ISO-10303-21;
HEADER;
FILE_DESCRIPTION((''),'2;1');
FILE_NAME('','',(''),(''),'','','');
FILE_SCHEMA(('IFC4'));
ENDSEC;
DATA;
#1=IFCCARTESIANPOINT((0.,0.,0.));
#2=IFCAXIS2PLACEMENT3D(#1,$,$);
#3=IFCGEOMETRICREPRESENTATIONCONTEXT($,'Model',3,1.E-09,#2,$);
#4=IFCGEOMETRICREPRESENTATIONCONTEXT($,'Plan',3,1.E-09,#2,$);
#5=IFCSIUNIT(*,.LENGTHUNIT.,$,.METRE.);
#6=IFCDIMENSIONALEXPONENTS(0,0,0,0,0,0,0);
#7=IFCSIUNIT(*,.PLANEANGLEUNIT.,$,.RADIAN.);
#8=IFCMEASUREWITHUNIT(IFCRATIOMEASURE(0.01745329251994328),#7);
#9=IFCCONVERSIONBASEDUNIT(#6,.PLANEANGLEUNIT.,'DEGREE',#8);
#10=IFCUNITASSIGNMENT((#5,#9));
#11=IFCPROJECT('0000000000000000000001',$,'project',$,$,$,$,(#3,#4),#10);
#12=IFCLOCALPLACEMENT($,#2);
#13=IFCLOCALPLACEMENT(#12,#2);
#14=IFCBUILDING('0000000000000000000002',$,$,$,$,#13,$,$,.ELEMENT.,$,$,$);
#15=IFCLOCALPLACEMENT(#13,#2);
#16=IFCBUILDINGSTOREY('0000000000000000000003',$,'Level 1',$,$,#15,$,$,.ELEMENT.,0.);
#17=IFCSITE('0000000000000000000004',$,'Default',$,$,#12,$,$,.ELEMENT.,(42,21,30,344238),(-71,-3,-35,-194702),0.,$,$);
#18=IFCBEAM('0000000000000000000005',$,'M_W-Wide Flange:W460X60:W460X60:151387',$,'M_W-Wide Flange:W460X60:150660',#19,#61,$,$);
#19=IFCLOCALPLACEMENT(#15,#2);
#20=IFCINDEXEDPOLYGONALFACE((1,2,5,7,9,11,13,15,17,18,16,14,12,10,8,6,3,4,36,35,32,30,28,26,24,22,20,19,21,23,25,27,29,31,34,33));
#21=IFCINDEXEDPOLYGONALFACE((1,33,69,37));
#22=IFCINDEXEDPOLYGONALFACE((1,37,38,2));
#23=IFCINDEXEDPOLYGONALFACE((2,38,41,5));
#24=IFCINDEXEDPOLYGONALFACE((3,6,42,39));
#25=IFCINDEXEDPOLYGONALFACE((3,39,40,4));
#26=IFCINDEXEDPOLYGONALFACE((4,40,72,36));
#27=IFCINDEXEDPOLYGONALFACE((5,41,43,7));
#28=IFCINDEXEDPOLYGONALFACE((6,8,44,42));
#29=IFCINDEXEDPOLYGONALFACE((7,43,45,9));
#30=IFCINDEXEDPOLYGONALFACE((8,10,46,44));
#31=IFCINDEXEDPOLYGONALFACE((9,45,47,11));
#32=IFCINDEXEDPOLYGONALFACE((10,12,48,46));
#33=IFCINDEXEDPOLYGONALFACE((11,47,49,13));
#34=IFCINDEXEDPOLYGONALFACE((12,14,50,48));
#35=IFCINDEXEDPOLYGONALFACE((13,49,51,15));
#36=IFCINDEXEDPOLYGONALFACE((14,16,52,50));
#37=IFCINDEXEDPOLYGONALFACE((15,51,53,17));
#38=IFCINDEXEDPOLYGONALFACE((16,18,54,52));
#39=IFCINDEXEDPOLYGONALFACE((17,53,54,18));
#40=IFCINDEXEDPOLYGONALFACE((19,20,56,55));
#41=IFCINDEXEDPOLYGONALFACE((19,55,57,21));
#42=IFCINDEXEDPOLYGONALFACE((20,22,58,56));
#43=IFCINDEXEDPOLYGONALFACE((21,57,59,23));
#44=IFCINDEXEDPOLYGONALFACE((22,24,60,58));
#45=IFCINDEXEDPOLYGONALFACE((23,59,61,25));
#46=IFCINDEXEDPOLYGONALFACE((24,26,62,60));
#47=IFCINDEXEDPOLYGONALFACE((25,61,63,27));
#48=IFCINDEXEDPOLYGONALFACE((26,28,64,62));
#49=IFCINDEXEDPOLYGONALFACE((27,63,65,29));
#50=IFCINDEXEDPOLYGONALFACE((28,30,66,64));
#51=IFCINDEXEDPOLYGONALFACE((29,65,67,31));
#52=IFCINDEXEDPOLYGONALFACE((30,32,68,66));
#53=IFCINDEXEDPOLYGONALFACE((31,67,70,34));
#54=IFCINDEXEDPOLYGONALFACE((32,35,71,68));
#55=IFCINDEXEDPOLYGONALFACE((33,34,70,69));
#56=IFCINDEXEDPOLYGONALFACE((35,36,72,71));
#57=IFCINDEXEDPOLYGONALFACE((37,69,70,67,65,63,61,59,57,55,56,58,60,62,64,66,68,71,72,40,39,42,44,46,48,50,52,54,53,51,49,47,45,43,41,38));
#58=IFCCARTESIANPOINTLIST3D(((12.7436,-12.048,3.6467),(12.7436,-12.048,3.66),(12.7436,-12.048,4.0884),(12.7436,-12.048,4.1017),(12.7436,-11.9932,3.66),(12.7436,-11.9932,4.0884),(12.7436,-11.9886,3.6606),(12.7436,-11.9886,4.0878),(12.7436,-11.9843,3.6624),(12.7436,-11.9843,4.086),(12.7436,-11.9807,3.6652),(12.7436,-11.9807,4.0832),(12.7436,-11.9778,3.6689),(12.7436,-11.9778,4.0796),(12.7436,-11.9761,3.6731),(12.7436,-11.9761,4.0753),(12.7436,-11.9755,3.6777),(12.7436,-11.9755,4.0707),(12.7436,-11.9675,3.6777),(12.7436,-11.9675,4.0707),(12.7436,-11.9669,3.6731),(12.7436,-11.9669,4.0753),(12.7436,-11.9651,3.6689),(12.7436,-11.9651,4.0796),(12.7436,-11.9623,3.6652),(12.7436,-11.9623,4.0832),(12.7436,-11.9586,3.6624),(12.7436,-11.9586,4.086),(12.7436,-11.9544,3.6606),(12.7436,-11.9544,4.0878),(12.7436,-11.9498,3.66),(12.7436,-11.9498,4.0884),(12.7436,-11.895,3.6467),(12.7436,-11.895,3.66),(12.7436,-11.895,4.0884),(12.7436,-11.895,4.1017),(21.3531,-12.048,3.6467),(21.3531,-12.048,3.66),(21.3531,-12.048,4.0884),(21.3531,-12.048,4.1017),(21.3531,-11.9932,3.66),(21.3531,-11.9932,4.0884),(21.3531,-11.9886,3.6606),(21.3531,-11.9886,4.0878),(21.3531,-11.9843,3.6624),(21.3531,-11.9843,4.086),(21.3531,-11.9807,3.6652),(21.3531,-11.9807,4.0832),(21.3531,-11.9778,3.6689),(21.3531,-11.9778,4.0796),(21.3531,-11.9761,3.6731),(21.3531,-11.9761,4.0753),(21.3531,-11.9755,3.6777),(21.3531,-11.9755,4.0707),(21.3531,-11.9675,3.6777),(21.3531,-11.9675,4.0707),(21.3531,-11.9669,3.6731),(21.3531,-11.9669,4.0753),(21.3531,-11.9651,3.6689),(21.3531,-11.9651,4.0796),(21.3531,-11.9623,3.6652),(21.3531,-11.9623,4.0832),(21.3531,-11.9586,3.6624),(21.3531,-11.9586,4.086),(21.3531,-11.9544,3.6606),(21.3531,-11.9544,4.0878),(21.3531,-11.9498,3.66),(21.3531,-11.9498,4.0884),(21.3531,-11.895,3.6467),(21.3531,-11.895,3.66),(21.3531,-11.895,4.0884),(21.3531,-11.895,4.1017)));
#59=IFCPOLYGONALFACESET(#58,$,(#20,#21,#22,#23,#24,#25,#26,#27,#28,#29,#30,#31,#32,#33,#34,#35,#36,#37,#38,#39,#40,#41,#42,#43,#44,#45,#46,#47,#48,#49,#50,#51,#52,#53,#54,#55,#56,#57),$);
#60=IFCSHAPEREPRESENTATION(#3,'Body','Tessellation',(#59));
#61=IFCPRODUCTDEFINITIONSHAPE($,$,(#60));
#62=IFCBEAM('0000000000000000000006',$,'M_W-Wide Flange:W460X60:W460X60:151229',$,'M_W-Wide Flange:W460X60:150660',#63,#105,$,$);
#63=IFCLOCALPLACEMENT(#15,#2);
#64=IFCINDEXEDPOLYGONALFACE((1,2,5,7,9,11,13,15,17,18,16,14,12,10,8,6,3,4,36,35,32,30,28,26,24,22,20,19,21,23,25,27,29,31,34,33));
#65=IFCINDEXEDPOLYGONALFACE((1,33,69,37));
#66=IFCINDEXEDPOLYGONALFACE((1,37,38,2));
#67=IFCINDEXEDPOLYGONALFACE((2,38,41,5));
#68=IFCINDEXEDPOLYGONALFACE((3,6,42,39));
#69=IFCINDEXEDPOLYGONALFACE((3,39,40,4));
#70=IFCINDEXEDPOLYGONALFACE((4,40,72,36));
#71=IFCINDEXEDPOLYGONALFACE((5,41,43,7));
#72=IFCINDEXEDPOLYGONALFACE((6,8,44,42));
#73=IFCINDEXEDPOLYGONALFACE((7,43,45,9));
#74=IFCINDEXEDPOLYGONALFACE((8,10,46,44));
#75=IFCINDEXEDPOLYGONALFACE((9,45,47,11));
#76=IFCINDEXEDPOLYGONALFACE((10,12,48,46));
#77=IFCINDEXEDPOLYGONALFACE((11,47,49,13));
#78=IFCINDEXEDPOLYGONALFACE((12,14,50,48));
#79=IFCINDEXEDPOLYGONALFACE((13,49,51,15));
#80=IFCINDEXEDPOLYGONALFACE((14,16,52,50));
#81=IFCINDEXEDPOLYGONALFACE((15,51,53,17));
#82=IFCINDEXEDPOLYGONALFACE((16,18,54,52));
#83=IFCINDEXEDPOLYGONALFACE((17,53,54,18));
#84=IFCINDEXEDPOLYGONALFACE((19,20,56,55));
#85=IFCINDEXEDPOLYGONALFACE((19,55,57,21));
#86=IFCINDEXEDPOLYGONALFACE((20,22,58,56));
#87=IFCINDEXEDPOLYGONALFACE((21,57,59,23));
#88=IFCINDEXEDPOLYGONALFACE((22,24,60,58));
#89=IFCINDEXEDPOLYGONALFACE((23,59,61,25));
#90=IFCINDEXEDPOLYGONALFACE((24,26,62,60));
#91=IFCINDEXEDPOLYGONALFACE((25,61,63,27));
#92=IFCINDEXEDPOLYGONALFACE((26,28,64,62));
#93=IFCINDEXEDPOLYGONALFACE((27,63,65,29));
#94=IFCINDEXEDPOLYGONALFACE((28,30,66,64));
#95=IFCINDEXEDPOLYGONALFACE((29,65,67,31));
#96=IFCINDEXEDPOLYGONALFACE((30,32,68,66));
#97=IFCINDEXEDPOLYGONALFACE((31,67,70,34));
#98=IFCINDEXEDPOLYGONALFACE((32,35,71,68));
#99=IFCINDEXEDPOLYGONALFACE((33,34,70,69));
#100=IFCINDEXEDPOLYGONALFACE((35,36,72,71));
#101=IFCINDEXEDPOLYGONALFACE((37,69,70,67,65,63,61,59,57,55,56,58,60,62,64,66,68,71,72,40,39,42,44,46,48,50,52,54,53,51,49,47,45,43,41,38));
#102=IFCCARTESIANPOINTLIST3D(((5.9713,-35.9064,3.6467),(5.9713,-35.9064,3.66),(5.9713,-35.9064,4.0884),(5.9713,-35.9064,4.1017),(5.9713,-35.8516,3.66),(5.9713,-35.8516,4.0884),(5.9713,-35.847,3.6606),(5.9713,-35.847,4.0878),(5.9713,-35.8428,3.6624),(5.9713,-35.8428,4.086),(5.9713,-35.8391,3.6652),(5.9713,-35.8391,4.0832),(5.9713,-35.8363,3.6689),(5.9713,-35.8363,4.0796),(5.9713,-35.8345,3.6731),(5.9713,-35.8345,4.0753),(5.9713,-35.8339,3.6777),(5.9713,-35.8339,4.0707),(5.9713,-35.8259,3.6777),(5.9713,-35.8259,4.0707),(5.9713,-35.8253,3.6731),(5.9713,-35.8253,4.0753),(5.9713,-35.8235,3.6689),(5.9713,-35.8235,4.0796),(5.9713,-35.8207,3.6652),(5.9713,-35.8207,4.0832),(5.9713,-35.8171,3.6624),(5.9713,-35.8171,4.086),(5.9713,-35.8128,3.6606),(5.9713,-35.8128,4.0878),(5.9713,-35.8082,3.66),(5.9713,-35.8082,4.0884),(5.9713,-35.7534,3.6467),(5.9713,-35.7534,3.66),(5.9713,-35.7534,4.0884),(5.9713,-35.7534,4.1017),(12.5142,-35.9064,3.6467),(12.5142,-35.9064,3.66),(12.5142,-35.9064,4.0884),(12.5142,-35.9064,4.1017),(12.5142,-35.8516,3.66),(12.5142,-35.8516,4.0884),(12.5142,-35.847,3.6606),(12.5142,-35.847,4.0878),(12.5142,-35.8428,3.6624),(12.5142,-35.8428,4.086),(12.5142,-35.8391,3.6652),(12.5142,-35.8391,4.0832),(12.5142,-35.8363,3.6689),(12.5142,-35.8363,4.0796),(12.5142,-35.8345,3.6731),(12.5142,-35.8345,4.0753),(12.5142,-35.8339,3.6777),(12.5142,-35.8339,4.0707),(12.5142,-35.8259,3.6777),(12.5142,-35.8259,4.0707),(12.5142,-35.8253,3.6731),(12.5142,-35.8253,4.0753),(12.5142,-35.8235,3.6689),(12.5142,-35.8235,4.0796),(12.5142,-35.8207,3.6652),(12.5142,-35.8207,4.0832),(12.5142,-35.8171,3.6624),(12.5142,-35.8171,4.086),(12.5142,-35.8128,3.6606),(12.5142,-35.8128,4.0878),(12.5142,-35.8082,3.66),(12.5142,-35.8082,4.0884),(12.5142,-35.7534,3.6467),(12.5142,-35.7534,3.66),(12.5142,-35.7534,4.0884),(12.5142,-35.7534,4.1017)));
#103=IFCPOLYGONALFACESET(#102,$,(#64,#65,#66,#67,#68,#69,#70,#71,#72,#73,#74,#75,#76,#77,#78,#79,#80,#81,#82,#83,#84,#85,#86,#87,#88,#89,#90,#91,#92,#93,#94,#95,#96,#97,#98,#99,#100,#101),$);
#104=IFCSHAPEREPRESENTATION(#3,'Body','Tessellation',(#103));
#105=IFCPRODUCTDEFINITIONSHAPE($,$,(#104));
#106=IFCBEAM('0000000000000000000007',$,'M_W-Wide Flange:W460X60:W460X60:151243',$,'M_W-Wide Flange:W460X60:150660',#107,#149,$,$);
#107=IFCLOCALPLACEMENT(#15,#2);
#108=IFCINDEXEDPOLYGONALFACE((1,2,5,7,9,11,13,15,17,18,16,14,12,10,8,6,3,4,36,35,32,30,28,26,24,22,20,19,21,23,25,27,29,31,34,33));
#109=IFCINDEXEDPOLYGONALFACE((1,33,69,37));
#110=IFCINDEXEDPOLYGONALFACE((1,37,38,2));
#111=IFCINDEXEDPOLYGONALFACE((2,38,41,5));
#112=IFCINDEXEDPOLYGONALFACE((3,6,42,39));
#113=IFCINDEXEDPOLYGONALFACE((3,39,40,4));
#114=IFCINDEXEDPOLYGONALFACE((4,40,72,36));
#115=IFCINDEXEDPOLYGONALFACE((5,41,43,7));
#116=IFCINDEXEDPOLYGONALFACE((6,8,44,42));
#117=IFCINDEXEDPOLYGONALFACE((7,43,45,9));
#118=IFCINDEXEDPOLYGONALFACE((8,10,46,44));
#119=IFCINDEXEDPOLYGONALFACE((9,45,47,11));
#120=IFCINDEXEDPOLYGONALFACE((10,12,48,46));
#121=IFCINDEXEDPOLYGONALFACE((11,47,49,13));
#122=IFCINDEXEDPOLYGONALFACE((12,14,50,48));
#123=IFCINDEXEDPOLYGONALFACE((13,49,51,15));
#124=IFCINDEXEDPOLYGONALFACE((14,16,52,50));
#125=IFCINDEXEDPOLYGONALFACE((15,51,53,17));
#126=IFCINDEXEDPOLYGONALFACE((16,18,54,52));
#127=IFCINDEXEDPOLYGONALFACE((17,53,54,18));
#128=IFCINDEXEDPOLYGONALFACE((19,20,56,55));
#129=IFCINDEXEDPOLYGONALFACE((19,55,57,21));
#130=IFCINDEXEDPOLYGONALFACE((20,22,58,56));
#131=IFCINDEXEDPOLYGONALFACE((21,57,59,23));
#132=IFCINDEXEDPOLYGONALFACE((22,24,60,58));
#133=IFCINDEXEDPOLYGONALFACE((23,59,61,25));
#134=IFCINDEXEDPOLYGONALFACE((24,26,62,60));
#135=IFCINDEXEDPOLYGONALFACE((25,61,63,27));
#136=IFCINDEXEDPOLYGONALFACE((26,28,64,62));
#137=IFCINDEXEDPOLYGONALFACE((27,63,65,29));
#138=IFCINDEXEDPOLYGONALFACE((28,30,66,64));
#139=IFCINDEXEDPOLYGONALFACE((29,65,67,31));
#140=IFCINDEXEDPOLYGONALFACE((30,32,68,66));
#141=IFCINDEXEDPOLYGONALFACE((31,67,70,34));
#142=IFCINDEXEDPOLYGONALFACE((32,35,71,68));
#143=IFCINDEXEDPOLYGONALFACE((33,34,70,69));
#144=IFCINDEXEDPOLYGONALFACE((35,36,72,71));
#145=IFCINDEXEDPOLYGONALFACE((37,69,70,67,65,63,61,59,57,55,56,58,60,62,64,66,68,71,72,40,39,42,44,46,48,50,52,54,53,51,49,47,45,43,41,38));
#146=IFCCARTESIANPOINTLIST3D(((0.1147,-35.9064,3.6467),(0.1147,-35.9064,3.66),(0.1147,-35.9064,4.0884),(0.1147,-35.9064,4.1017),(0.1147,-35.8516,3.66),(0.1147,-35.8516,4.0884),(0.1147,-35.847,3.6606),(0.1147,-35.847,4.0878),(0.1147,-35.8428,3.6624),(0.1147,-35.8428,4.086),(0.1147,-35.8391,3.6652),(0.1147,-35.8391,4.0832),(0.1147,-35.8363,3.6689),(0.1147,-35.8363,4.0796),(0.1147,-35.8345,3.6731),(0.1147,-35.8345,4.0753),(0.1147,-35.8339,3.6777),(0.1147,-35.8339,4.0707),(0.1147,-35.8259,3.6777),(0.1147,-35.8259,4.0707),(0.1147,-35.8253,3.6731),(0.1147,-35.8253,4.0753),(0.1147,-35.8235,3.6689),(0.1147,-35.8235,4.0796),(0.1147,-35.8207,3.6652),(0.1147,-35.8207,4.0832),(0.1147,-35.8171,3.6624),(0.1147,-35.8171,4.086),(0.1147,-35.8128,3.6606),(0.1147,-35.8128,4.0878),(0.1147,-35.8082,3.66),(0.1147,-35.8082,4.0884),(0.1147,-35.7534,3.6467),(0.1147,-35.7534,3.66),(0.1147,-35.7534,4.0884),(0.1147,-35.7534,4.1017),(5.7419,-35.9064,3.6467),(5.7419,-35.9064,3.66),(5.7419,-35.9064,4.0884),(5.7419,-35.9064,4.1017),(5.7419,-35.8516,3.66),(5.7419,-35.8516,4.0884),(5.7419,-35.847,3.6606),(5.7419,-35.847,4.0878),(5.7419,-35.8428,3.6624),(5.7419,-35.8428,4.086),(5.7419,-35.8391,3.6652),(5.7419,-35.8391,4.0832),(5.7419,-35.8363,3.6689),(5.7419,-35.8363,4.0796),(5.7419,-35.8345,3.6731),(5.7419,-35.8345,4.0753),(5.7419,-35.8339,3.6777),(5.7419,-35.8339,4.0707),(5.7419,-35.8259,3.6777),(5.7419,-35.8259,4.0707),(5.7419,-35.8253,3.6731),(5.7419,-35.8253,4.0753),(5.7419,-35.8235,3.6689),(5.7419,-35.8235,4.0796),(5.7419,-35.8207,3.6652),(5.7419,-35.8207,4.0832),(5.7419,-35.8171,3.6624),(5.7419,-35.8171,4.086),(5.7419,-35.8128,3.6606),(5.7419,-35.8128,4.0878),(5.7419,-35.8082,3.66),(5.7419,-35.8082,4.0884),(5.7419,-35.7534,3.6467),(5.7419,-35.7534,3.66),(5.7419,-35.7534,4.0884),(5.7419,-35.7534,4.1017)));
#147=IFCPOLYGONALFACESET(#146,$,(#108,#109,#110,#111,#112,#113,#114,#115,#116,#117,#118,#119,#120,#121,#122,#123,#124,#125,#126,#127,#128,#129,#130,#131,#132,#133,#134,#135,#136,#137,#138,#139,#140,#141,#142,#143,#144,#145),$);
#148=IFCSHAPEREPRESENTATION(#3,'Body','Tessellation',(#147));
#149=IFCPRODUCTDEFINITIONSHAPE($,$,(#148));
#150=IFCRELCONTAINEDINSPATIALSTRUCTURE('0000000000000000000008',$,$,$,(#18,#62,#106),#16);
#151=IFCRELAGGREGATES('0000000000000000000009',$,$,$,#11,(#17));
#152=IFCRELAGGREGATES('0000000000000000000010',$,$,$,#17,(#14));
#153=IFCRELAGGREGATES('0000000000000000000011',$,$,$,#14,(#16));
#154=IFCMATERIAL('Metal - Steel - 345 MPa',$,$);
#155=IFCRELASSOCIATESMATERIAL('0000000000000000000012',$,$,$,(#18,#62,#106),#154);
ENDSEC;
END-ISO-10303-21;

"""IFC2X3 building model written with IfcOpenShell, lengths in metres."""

from ifc_helpers import new_model, entity, si_unit, converted_unit, frame, frame_2d, origin, place, context, project, spatial, polyline, circle_curve, parameter, trimmed, segment, composite_curve, outline, extrude, material, element, save


model = new_model("IFC2X3")

# Units and contexts
model_context = context("Model", 3, precision=1e-09, world=origin())
plan_context = context("Plan", 3, precision=1e-09, world=origin())
ifc_project = project(units=[si_unit("LENGTHUNIT", "METRE"), converted_unit("PLANEANGLEUNIT", "DEGREE", entity("IfcRatioMeasure", 0.01745329251994328), si_unit("PLANEANGLEUNIT", "RADIAN"), dimensions=[0, 0, 0, 0, 0, 0, 0])], contexts=[model_context, plan_context])

# Site, building, storey
site_placement = place(None, origin())
site = spatial("IfcSite", under=ifc_project, at=site_placement, Name="Default", CompositionType="ELEMENT", RefLatitude=(42, 21, 30, 344238), RefLongitude=(-71, -3, -35, -194702), RefElevation=0.0)
building_placement = place(site_placement, origin())
building = spatial("IfcBuilding", under=site, at=building_placement, CompositionType="ELEMENT")
storey_placement = place(building_placement, origin())
storey = spatial("IfcBuildingStorey", under=building, at=storey_placement, Name="Level 1", CompositionType="ELEMENT", Elevation=0.0)

# Beams
ifc_material_1 = material(Name="Metal - Steel - 345 MPa")
beam_1_placement = place(storey_placement, frame((12.6289, -11.9715, 4.2672), z_axis=(0.0, 0.0, 1.0), x_axis=(0.0, -1.0, 0.0)))
element("IfcBeam", 1, at=beam_1_placement, inside=storey, material=ifc_material_1, Name="M_W-Wide Flange:W460X60:W460X60:151387", ObjectType="M_W-Wide Flange:W460X60:150660", context=model_context, shape_type="SweptSolid", body=[
    extrude(outline(composite_curve([segment(polyline([(-0.0765, -0.2142), (-0.0765, -0.2275)]), True, "CONTINUOUS"), segment(polyline([(-0.0765, -0.2275), (0.0765, -0.2275)]), True, "CONTINUOUS"), segment(polyline([(0.0765, -0.2275), (0.0765, -0.2142)]), True, "CONTINUOUS"), segment(polyline([(0.0765, -0.2142), (0.0217, -0.2142)]), True, "CONTINUOUS"), segment(trimmed(circle_curve(frame_2d((0.0217, -0.1965), x_axis=(0.0, -1.0)), 0.0177), [parameter(270.0)], [parameter(360.0)], True, "PARAMETER"), False, "CONTINUOUS"), segment(polyline([(0.004, -0.1965), (0.004, 0.1965)]), True, "CONTINUOUS"), segment(trimmed(circle_curve(frame_2d((0.0217, 0.1965), x_axis=(-1.0, 0.0)), 0.0177), [parameter(270.0)], [parameter(360.0)], True, "PARAMETER"), False, "CONTINUOUS"), segment(polyline([(0.0217, 0.2142), (0.0765, 0.2142)]), True, "CONTINUOUS"), segment(polyline([(0.0765, 0.2142), (0.0765, 0.2275)]), True, "CONTINUOUS"), segment(polyline([(0.0765, 0.2275), (-0.0765, 0.2275)]), True, "CONTINUOUS"), segment(polyline([(-0.0765, 0.2275), (-0.0765, 0.2142)]), True, "CONTINUOUS"), segment(polyline([(-0.0765, 0.2142), (-0.0217, 0.2142)]), True, "CONTINUOUS"), segment(trimmed(circle_curve(frame_2d((-0.0217, 0.1965), x_axis=(0.0, 1.0)), 0.0177), [parameter(270.0)], [parameter(360.0)], True, "PARAMETER"), False, "CONTINUOUS"), segment(polyline([(-0.004, 0.1965), (-0.004, -0.1965)]), True, "CONTINUOUS"), segment(trimmed(circle_curve(frame_2d((-0.0217, -0.1965), x_axis=(1.0, 0.0)), 0.0177), [parameter(270.0)], [parameter(0.0)], True, "PARAMETER"), False, "CONTINUOUS"), segment(polyline([(-0.0217, -0.2142), (-0.0765, -0.2142)]), True, "CONTINUOUS")], self_intersect=False)), frame((0.0, 0.1147, -0.393), z_axis=(0.0, -1.0, 0.0), x_axis=(1.0, 0.0, 0.0)), (0.0, 0.0, -1.0), 8.6095),
])
beam_2_placement = place(storey_placement, frame((12.6289, -35.8299, 4.2672), z_axis=(0.0, 0.0, 1.0), x_axis=(0.0, 1.0, 0.0)))
element("IfcBeam", 2, at=beam_2_placement, inside=storey, material=ifc_material_1, Name="M_W-Wide Flange:W460X60:W460X60:151229", ObjectType="M_W-Wide Flange:W460X60:150660", context=model_context, shape_type="SweptSolid", body=[
    extrude(outline(composite_curve([segment(polyline([(0.2142, -0.0765), (0.2275, -0.0765)]), True, "CONTINUOUS"), segment(polyline([(0.2275, -0.0765), (0.2275, 0.0765)]), True, "CONTINUOUS"), segment(polyline([(0.2275, 0.0765), (0.2142, 0.0765)]), True, "CONTINUOUS"), segment(polyline([(0.2142, 0.0765), (0.2142, 0.0217)]), True, "CONTINUOUS"), segment(trimmed(circle_curve(frame_2d((0.1965, 0.0217), x_axis=(1.0, 0.0)), 0.0177), [parameter(270.0)], [parameter(360.0)], True, "PARAMETER"), False, "CONTINUOUS"), segment(polyline([(0.1965, 0.004), (-0.1965, 0.004)]), True, "CONTINUOUS"), segment(trimmed(circle_curve(frame_2d((-0.1965, 0.0217), x_axis=(0.0, -1.0)), 0.0177), [parameter(270.0)], [parameter(360.0)], True, "PARAMETER"), False, "CONTINUOUS"), segment(polyline([(-0.2142, 0.0217), (-0.2142, 0.0765)]), True, "CONTINUOUS"), segment(polyline([(-0.2142, 0.0765), (-0.2275, 0.0765)]), True, "CONTINUOUS"), segment(polyline([(-0.2275, 0.0765), (-0.2275, -0.0765)]), True, "CONTINUOUS"), segment(polyline([(-0.2275, -0.0765), (-0.2142, -0.0765)]), True, "CONTINUOUS"), segment(polyline([(-0.2142, -0.0765), (-0.2142, -0.0217)]), True, "CONTINUOUS"), segment(trimmed(circle_curve(frame_2d((-0.1965, -0.0217), x_axis=(-1.0, 0.0)), 0.0177), [parameter(270.0)], [parameter(360.0)], True, "PARAMETER"), False, "CONTINUOUS"), segment(polyline([(-0.1965, -0.004), (0.1965, -0.004)]), True, "CONTINUOUS"), segment(trimmed(circle_curve(frame_2d((0.1965, -0.0217), x_axis=(0.0, 1.0)), 0.0177), [parameter(270.0)], [parameter(0.0)], True, "PARAMETER"), False, "CONTINUOUS"), segment(polyline([(0.2142, -0.0217), (0.2142, -0.0765)]), True, "CONTINUOUS")], self_intersect=False)), frame((0.0, 6.6576, -0.393), z_axis=(0.0, -1.0, 0.0), x_axis=(0.0, 0.0, -1.0)), (0.0, 0.0, 1.0), 6.5429),
])
beam_3_placement = place(storey_placement, frame((5.8566, -35.8299, 4.2672), z_axis=(0.0, 0.0, 1.0), x_axis=(0.0, 1.0, 0.0)))
element("IfcBeam", 3, at=beam_3_placement, inside=storey, material=ifc_material_1, Name="M_W-Wide Flange:W460X60:W460X60:151243", ObjectType="M_W-Wide Flange:W460X60:150660", context=model_context, shape_type="SweptSolid", body=[
    extrude(outline(composite_curve([segment(polyline([(0.2142, -0.0765), (0.2275, -0.0765)]), True, "CONTINUOUS"), segment(polyline([(0.2275, -0.0765), (0.2275, 0.0765)]), True, "CONTINUOUS"), segment(polyline([(0.2275, 0.0765), (0.2142, 0.0765)]), True, "CONTINUOUS"), segment(polyline([(0.2142, 0.0765), (0.2142, 0.0217)]), True, "CONTINUOUS"), segment(trimmed(circle_curve(frame_2d((0.1965, 0.0217), x_axis=(1.0, 0.0)), 0.0177), [parameter(270.0)], [parameter(360.0)], True, "PARAMETER"), False, "CONTINUOUS"), segment(polyline([(0.1965, 0.004), (-0.1965, 0.004)]), True, "CONTINUOUS"), segment(trimmed(circle_curve(frame_2d((-0.1965, 0.0217), x_axis=(0.0, -1.0)), 0.0177), [parameter(270.0)], [parameter(360.0)], True, "PARAMETER"), False, "CONTINUOUS"), segment(polyline([(-0.2142, 0.0217), (-0.2142, 0.0765)]), True, "CONTINUOUS"), segment(polyline([(-0.2142, 0.0765), (-0.2275, 0.0765)]), True, "CONTINUOUS"), segment(polyline([(-0.2275, 0.0765), (-0.2275, -0.0765)]), True, "CONTINUOUS"), segment(polyline([(-0.2275, -0.0765), (-0.2142, -0.0765)]), True, "CONTINUOUS"), segment(polyline([(-0.2142, -0.0765), (-0.2142, -0.0217)]), True, "CONTINUOUS"), segment(trimmed(circle_curve(frame_2d((-0.1965, -0.0217), x_axis=(-1.0, 0.0)), 0.0177), [parameter(270.0)], [parameter(360.0)], True, "PARAMETER"), False, "CONTINUOUS"), segment(polyline([(-0.1965, -0.004), (0.1965, -0.004)]), True, "CONTINUOUS"), segment(trimmed(circle_curve(frame_2d((0.1965, -0.0217), x_axis=(0.0, 1.0)), 0.0177), [parameter(270.0)], [parameter(0.0)], True, "PARAMETER"), False, "CONTINUOUS"), segment(polyline([(0.2142, -0.0217), (0.2142, -0.0765)]), True, "CONTINUOUS")], self_intersect=False)), frame((0.0, 5.7419, -0.393), z_axis=(0.0, -1.0, 0.0), x_axis=(0.0, 0.0, -1.0)), (0.0, 0.0, 1.0), 5.6272),
])

save(model, "model.ifc")
